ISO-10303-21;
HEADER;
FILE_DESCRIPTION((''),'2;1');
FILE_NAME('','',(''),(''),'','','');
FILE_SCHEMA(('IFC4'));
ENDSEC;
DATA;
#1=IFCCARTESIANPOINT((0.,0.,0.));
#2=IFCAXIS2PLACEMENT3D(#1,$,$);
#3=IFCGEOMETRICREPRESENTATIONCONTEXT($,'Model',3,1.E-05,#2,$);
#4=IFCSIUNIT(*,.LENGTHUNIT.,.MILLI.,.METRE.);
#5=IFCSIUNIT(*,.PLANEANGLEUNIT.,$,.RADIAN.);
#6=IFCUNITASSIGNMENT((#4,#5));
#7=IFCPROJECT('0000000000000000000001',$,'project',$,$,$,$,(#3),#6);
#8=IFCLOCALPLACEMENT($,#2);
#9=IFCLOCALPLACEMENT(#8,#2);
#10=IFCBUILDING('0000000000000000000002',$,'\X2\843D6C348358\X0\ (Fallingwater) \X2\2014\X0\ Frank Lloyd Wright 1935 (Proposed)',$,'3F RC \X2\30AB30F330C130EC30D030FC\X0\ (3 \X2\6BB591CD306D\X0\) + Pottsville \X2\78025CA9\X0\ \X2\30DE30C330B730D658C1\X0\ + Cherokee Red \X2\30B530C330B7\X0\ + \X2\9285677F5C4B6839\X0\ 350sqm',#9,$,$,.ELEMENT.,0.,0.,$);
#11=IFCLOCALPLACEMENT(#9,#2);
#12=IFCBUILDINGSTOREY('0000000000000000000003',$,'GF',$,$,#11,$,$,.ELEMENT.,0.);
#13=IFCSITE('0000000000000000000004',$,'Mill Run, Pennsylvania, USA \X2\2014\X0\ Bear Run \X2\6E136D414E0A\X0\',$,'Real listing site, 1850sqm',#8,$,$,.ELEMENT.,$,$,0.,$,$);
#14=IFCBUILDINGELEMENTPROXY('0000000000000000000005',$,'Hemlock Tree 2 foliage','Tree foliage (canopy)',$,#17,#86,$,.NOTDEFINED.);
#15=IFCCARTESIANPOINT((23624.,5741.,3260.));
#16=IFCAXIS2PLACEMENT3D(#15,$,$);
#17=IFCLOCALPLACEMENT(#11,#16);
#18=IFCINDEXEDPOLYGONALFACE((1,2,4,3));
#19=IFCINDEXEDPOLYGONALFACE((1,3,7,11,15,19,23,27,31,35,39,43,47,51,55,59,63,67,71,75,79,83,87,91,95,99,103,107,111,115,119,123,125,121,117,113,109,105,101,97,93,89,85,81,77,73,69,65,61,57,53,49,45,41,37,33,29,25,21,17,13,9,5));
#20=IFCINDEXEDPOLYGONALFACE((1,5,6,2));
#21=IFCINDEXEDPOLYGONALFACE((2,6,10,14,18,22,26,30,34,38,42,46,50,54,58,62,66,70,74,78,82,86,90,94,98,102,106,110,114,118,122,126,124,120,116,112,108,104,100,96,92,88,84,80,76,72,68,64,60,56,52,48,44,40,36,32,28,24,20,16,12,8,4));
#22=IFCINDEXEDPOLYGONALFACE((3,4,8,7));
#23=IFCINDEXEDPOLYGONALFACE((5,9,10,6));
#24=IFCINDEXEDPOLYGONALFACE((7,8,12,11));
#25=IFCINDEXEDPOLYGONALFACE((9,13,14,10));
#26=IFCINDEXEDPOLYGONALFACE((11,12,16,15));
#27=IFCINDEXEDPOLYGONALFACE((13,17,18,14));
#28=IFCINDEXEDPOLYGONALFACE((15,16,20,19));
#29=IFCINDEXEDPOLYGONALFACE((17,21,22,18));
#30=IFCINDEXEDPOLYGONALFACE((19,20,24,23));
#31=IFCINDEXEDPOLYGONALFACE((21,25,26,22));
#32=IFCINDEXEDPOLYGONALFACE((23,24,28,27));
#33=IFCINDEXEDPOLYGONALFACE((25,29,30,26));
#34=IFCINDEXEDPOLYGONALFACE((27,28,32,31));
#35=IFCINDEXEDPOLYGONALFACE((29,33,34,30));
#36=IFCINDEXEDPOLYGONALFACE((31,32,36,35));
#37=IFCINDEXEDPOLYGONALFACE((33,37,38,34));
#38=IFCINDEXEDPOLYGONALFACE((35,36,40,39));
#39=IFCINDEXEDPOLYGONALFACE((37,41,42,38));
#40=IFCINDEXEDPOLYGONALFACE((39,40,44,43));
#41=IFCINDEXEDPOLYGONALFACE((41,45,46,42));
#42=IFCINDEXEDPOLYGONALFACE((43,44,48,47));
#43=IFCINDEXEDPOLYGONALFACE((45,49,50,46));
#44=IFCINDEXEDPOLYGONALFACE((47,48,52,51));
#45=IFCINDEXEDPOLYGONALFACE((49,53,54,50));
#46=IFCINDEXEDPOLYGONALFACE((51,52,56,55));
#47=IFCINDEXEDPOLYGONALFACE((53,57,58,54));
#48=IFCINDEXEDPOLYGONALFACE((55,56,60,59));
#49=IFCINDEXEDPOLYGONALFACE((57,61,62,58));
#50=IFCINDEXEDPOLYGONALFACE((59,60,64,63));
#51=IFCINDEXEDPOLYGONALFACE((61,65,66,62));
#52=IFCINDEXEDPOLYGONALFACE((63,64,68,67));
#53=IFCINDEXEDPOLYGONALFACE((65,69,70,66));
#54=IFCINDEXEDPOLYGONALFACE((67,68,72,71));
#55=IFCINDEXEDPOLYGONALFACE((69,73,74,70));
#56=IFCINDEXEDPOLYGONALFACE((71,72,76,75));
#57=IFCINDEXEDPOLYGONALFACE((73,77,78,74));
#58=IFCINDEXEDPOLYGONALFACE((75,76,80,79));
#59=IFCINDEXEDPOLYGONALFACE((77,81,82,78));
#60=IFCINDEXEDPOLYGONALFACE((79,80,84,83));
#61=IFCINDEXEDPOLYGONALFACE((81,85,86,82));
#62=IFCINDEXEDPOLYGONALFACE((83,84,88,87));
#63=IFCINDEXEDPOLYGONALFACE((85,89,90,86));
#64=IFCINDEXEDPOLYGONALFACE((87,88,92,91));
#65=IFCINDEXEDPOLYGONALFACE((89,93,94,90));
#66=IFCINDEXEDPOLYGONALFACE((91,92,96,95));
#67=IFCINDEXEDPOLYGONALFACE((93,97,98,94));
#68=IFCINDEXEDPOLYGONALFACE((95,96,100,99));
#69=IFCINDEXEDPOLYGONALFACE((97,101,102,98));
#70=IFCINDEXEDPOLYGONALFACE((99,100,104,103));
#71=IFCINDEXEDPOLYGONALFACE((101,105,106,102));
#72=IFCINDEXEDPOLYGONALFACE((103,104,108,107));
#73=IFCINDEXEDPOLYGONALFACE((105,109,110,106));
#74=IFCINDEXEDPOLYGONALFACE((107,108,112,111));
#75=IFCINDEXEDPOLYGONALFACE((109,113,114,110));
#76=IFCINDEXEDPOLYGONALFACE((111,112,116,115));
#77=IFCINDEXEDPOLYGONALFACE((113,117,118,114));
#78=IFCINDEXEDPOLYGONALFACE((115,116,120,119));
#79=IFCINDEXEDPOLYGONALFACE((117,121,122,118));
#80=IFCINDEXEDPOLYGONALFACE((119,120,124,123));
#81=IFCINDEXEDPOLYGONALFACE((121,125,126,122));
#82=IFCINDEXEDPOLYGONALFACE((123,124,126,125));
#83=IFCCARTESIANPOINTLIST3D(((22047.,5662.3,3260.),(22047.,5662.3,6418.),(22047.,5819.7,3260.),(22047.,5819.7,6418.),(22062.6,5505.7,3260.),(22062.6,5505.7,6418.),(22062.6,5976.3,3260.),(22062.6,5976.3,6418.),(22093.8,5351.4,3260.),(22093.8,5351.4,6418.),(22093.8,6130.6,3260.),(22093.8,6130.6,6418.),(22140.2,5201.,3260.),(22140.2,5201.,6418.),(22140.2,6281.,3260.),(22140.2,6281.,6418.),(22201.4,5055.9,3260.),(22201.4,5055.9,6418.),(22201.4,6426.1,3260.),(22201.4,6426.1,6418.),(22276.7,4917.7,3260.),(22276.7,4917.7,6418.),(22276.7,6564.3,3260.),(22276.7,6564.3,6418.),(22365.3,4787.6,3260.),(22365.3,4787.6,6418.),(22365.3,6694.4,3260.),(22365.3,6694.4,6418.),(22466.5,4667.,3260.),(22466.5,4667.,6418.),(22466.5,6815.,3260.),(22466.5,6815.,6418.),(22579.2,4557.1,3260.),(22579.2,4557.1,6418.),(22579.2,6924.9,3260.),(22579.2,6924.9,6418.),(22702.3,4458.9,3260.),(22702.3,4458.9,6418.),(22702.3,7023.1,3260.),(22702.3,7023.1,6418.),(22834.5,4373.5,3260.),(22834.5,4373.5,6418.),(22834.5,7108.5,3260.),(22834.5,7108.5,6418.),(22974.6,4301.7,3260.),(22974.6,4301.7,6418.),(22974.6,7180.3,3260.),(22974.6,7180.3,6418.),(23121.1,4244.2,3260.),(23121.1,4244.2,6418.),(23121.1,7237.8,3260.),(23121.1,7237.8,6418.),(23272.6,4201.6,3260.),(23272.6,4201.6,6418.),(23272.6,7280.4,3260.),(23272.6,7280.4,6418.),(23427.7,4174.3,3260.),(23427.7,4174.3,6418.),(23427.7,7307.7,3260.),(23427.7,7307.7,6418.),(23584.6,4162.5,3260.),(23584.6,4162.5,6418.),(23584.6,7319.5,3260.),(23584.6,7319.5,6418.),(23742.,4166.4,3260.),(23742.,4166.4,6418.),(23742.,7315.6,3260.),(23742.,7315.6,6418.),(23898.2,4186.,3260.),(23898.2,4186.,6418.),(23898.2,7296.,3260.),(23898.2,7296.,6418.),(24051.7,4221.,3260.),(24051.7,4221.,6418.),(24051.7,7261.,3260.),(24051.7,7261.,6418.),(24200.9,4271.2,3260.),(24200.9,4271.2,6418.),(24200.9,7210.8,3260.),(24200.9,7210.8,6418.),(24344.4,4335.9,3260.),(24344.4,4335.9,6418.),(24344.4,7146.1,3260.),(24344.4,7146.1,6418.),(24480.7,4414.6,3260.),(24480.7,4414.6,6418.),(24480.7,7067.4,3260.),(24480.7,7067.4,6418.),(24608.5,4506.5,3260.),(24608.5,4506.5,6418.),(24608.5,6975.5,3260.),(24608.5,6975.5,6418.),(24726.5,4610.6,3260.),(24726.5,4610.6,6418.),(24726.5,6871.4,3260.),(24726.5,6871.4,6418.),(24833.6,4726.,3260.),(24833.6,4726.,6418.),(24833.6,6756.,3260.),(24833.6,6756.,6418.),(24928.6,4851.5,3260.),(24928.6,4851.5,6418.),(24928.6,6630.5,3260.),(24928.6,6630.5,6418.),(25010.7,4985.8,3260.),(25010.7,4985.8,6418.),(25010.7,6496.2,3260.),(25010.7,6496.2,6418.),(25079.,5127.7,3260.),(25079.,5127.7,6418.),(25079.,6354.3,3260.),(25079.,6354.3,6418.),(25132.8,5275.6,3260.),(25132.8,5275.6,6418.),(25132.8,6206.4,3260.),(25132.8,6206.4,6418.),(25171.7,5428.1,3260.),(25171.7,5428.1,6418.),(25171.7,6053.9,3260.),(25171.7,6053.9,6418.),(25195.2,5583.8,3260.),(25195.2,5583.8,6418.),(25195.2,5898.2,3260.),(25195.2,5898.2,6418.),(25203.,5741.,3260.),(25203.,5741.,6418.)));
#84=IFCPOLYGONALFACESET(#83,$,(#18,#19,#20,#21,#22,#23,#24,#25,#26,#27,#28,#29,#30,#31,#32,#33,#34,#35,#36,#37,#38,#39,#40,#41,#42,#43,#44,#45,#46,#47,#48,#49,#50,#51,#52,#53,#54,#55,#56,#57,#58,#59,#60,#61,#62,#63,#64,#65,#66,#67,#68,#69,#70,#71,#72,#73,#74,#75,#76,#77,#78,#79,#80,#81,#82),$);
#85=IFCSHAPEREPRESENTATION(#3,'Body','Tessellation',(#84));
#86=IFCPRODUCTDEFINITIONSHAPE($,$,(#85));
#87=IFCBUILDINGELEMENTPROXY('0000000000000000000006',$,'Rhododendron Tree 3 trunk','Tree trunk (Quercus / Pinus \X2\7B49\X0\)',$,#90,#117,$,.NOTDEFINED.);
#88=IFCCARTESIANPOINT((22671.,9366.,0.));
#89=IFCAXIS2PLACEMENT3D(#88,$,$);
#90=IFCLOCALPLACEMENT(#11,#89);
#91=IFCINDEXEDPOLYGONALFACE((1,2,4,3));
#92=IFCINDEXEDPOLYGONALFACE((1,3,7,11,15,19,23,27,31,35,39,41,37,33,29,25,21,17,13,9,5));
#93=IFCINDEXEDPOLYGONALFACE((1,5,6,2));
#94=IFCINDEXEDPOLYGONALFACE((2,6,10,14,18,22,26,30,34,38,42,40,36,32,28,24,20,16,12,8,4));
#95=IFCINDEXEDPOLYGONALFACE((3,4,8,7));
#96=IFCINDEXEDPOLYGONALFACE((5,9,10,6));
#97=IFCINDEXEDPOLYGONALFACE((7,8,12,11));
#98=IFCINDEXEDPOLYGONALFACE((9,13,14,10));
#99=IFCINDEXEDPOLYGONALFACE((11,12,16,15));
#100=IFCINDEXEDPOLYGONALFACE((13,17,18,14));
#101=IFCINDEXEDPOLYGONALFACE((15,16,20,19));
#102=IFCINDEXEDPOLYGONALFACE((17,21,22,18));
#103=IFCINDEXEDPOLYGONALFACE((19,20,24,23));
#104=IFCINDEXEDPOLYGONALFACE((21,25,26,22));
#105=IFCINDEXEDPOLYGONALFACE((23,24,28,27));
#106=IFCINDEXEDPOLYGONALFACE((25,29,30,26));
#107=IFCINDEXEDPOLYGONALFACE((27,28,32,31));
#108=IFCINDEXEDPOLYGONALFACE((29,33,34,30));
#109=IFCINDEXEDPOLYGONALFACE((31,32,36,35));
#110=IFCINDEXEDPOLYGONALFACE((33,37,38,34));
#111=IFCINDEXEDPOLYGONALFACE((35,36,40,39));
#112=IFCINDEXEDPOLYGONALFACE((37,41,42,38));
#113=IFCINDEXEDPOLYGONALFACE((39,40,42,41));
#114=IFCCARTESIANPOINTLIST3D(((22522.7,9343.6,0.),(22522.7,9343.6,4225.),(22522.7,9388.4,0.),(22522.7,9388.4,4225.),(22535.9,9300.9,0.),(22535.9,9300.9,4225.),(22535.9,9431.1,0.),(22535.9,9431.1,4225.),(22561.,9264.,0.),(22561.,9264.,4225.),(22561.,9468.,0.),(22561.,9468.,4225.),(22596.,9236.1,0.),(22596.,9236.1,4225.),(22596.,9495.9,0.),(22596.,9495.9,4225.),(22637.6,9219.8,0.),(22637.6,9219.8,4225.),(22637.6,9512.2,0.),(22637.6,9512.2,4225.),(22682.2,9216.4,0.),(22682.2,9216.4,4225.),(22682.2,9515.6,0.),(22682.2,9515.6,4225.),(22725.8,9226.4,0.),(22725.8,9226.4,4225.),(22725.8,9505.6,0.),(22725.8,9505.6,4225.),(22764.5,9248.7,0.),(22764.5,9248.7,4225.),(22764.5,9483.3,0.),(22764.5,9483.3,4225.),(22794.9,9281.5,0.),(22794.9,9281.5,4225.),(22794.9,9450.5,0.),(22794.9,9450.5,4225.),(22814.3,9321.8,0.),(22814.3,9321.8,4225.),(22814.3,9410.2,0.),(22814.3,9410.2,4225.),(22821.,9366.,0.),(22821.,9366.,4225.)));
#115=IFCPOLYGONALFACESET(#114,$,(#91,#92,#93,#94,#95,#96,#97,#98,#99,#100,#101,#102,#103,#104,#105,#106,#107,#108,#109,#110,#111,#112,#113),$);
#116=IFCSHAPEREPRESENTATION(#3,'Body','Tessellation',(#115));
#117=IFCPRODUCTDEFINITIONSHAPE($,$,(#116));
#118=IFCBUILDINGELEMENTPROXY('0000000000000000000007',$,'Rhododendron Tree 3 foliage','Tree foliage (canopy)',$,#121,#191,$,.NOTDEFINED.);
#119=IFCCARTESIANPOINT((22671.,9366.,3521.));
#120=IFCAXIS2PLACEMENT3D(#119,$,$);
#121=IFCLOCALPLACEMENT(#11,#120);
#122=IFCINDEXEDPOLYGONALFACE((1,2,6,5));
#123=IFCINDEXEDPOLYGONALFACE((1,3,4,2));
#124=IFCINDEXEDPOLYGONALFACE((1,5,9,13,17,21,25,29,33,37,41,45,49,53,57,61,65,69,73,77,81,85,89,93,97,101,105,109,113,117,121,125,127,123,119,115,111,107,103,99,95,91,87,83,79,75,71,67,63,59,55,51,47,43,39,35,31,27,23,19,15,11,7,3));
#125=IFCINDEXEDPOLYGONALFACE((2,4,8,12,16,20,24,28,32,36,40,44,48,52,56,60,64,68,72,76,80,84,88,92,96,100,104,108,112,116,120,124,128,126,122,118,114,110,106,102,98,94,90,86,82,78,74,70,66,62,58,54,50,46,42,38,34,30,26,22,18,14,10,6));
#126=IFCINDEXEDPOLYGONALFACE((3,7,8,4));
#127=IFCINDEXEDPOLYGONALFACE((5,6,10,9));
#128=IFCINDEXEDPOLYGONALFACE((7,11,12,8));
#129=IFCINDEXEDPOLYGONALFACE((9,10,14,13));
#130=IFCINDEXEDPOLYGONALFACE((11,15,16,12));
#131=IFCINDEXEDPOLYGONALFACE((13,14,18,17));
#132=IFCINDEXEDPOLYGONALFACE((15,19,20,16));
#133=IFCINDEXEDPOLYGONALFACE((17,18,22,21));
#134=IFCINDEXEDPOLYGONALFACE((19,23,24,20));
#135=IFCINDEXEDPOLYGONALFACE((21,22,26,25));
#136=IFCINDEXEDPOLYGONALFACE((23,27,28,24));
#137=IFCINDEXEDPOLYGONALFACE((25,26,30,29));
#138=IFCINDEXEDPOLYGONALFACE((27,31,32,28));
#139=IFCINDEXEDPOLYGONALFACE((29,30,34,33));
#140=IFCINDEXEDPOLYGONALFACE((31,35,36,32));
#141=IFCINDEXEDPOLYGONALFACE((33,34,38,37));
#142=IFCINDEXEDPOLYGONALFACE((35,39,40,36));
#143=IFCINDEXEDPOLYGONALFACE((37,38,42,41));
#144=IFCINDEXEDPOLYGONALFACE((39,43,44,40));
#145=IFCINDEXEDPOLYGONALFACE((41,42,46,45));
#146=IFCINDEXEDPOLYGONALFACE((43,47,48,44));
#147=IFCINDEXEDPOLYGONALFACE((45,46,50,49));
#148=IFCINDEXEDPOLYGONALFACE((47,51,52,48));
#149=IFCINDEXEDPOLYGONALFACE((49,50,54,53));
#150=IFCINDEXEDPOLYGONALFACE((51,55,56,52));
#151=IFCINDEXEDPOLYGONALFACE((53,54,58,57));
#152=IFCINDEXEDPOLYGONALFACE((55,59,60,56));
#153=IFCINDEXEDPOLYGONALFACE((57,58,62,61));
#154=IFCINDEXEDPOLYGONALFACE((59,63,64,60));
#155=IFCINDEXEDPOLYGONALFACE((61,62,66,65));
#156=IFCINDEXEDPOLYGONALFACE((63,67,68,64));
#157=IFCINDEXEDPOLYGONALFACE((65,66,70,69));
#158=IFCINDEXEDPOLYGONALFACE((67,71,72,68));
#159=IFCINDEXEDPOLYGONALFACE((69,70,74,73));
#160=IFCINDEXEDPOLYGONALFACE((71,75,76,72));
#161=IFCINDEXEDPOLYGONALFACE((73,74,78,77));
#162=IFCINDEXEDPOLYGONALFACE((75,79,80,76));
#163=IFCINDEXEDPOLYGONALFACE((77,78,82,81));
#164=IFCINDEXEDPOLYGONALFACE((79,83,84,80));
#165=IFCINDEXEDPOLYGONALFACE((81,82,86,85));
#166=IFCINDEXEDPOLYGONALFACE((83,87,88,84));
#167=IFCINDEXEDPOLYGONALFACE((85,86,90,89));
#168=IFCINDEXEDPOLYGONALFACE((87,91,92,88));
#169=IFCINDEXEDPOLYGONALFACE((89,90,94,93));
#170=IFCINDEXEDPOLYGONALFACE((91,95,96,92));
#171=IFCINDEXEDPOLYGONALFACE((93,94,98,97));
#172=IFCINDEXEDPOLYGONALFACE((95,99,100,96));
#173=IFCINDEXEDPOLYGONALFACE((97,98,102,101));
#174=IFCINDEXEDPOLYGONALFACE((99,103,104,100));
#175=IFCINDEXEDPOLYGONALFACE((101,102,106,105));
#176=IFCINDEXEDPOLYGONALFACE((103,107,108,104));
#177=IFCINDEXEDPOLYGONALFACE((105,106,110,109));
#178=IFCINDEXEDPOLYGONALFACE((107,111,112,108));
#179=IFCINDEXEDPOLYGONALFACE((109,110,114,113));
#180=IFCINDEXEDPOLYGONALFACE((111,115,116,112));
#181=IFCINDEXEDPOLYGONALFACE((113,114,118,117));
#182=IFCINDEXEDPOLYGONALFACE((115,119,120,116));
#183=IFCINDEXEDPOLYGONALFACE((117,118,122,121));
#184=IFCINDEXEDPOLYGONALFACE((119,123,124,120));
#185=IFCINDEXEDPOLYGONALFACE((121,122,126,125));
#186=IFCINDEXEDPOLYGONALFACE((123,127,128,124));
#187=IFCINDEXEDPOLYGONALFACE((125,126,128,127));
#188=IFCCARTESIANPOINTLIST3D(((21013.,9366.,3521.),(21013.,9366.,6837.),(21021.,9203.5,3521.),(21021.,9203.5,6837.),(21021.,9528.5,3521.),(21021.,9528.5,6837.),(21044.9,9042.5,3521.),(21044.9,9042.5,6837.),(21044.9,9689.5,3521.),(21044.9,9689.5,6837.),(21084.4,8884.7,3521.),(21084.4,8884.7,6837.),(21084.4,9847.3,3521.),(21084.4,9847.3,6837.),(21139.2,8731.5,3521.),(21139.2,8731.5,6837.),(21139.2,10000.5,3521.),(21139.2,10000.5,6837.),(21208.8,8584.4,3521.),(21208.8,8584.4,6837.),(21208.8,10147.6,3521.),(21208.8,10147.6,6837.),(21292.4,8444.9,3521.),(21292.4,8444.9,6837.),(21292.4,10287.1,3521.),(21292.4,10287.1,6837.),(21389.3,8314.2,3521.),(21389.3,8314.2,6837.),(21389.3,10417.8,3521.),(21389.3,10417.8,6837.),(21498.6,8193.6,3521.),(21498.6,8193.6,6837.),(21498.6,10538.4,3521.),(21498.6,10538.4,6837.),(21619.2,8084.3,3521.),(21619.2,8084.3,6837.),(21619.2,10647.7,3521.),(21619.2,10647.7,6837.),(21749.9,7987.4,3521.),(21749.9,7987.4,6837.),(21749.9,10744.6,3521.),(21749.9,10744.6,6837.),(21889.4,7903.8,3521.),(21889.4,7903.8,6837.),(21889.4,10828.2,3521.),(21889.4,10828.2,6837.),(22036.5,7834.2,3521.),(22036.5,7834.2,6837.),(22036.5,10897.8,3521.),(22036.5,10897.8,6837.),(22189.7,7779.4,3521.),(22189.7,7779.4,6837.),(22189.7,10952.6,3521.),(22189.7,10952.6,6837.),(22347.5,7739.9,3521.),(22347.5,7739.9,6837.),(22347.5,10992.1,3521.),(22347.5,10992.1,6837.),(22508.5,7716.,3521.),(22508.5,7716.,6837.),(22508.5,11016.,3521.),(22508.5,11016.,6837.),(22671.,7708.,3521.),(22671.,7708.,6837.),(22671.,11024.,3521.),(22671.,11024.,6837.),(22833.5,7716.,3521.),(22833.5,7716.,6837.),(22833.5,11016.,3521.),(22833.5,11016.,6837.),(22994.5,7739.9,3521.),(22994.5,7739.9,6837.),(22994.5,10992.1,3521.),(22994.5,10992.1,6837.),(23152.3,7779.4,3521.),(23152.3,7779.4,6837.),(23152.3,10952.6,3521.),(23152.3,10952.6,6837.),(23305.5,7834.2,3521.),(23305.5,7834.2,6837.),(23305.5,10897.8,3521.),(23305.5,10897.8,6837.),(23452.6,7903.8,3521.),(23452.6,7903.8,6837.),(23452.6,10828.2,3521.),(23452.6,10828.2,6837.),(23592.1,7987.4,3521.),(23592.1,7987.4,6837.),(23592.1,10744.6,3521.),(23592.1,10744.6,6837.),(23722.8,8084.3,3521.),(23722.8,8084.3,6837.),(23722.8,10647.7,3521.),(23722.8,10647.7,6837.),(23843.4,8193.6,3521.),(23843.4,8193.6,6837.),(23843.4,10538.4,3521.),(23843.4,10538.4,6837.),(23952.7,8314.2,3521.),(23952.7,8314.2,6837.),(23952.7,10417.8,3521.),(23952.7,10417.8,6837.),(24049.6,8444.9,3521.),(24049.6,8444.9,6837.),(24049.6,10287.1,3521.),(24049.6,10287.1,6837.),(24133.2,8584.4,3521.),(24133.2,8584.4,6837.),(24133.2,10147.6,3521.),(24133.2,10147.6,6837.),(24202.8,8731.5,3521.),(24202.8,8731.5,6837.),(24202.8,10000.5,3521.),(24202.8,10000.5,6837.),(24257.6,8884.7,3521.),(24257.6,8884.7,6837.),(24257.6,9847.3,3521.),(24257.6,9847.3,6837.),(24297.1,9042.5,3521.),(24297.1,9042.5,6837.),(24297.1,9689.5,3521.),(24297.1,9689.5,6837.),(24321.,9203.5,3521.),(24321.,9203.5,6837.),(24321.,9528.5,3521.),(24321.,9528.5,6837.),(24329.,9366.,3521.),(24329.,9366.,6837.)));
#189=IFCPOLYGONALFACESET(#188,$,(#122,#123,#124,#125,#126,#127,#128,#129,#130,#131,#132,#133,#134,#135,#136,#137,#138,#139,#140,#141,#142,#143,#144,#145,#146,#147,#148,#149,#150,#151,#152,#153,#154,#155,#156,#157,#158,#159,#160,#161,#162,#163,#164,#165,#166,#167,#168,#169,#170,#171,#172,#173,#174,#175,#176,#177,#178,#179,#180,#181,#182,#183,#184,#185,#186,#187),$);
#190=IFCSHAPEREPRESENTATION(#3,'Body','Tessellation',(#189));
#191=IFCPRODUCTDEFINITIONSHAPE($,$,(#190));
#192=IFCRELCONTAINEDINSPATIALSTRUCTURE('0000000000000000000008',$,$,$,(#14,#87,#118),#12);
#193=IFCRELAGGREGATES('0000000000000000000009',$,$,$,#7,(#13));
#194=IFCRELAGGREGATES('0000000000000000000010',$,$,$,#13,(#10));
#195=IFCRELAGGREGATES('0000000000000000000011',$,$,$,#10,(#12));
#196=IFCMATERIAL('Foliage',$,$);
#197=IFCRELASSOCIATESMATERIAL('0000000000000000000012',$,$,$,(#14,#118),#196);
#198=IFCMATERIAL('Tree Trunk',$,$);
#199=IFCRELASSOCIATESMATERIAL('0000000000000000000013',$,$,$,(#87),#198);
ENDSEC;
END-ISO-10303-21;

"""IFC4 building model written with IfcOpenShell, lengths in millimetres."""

from ifc_helpers import new_model, si_unit, frame, origin, origin_2d, place, context, project, spatial, circle, extrude, material, element, save


model = new_model("IFC4")

# Units and contexts
model_context = context("Model", 3, precision=1e-05, world=origin())
ifc_project = project(units=[si_unit("LENGTHUNIT", "METRE", prefix="MILLI"), si_unit("PLANEANGLEUNIT", "RADIAN")], contexts=[model_context])

# Site, building, storey
site_placement = place(None, origin())
site = spatial("IfcSite", under=ifc_project, at=site_placement, Name="Mill Run, Pennsylvania, USA — Bear Run 渓流上", ObjectType="Real listing site, 1850sqm", CompositionType="ELEMENT", RefElevation=0.0)
building_placement = place(site_placement, origin())
building = spatial("IfcBuilding", under=site, at=building_placement, Name="落水荘 (Fallingwater) — Frank Lloyd Wright 1935 (Proposed)", ObjectType="3F RC カンチレバー (3 段重ね) + Pottsville 砂岩 マッシブ壁 + Cherokee Red サッシ + 銅板屋根 350sqm", CompositionType="ELEMENT", ElevationOfRefHeight=0.0, ElevationOfTerrain=0.0)
storey_placement = place(building_placement, origin())
storey = spatial("IfcBuildingStorey", under=building, at=storey_placement, Name="GF", CompositionType="ELEMENT", Elevation=0.0)

# Building element proxies
ifc_material_1 = material(Name="Tree Trunk")
ifc_material_2 = material(Name="Foliage")
proxy_1_placement = place(storey_placement, frame((23624.0, 5741.0, 3260.0)))
element("IfcBuildingElementProxy", 1, at=proxy_1_placement, inside=storey, material=ifc_material_2, Name="Hemlock Tree 2 foliage", Description="Tree foliage (canopy)", PredefinedType="NOTDEFINED", context=model_context, shape_type="SweptSolid", body=[
    extrude(circle(Radius=1579.0, at=origin_2d()), frame((23624.0, 5741.0, 3260.0)), (0.0, 0.0, 1.0), 3158.0),
])
proxy_2_placement = place(storey_placement, frame((22671.0, 9366.0, 0.0)))
element("IfcBuildingElementProxy", 2, at=proxy_2_placement, inside=storey, material=ifc_material_1, Name="Rhododendron Tree 3 trunk", Description="Tree trunk (Quercus / Pinus 等)", PredefinedType="NOTDEFINED", context=model_context, shape_type="SweptSolid", body=[
    extrude(circle(Radius=150.0, at=origin_2d()), frame((22671.0, 9366.0, 0.0)), (0.0, 0.0, 1.0), 4225.0),
])
proxy_3_placement = place(storey_placement, frame((22671.0, 9366.0, 3521.0)))
element("IfcBuildingElementProxy", 3, at=proxy_3_placement, inside=storey, material=ifc_material_2, Name="Rhododendron Tree 3 foliage", Description="Tree foliage (canopy)", PredefinedType="NOTDEFINED", context=model_context, shape_type="SweptSolid", body=[
    extrude(circle(Radius=1658.0, at=origin_2d()), frame((22671.0, 9366.0, 3521.0)), (0.0, 0.0, 1.0), 3316.0),
])

save(model, "model.ifc")
